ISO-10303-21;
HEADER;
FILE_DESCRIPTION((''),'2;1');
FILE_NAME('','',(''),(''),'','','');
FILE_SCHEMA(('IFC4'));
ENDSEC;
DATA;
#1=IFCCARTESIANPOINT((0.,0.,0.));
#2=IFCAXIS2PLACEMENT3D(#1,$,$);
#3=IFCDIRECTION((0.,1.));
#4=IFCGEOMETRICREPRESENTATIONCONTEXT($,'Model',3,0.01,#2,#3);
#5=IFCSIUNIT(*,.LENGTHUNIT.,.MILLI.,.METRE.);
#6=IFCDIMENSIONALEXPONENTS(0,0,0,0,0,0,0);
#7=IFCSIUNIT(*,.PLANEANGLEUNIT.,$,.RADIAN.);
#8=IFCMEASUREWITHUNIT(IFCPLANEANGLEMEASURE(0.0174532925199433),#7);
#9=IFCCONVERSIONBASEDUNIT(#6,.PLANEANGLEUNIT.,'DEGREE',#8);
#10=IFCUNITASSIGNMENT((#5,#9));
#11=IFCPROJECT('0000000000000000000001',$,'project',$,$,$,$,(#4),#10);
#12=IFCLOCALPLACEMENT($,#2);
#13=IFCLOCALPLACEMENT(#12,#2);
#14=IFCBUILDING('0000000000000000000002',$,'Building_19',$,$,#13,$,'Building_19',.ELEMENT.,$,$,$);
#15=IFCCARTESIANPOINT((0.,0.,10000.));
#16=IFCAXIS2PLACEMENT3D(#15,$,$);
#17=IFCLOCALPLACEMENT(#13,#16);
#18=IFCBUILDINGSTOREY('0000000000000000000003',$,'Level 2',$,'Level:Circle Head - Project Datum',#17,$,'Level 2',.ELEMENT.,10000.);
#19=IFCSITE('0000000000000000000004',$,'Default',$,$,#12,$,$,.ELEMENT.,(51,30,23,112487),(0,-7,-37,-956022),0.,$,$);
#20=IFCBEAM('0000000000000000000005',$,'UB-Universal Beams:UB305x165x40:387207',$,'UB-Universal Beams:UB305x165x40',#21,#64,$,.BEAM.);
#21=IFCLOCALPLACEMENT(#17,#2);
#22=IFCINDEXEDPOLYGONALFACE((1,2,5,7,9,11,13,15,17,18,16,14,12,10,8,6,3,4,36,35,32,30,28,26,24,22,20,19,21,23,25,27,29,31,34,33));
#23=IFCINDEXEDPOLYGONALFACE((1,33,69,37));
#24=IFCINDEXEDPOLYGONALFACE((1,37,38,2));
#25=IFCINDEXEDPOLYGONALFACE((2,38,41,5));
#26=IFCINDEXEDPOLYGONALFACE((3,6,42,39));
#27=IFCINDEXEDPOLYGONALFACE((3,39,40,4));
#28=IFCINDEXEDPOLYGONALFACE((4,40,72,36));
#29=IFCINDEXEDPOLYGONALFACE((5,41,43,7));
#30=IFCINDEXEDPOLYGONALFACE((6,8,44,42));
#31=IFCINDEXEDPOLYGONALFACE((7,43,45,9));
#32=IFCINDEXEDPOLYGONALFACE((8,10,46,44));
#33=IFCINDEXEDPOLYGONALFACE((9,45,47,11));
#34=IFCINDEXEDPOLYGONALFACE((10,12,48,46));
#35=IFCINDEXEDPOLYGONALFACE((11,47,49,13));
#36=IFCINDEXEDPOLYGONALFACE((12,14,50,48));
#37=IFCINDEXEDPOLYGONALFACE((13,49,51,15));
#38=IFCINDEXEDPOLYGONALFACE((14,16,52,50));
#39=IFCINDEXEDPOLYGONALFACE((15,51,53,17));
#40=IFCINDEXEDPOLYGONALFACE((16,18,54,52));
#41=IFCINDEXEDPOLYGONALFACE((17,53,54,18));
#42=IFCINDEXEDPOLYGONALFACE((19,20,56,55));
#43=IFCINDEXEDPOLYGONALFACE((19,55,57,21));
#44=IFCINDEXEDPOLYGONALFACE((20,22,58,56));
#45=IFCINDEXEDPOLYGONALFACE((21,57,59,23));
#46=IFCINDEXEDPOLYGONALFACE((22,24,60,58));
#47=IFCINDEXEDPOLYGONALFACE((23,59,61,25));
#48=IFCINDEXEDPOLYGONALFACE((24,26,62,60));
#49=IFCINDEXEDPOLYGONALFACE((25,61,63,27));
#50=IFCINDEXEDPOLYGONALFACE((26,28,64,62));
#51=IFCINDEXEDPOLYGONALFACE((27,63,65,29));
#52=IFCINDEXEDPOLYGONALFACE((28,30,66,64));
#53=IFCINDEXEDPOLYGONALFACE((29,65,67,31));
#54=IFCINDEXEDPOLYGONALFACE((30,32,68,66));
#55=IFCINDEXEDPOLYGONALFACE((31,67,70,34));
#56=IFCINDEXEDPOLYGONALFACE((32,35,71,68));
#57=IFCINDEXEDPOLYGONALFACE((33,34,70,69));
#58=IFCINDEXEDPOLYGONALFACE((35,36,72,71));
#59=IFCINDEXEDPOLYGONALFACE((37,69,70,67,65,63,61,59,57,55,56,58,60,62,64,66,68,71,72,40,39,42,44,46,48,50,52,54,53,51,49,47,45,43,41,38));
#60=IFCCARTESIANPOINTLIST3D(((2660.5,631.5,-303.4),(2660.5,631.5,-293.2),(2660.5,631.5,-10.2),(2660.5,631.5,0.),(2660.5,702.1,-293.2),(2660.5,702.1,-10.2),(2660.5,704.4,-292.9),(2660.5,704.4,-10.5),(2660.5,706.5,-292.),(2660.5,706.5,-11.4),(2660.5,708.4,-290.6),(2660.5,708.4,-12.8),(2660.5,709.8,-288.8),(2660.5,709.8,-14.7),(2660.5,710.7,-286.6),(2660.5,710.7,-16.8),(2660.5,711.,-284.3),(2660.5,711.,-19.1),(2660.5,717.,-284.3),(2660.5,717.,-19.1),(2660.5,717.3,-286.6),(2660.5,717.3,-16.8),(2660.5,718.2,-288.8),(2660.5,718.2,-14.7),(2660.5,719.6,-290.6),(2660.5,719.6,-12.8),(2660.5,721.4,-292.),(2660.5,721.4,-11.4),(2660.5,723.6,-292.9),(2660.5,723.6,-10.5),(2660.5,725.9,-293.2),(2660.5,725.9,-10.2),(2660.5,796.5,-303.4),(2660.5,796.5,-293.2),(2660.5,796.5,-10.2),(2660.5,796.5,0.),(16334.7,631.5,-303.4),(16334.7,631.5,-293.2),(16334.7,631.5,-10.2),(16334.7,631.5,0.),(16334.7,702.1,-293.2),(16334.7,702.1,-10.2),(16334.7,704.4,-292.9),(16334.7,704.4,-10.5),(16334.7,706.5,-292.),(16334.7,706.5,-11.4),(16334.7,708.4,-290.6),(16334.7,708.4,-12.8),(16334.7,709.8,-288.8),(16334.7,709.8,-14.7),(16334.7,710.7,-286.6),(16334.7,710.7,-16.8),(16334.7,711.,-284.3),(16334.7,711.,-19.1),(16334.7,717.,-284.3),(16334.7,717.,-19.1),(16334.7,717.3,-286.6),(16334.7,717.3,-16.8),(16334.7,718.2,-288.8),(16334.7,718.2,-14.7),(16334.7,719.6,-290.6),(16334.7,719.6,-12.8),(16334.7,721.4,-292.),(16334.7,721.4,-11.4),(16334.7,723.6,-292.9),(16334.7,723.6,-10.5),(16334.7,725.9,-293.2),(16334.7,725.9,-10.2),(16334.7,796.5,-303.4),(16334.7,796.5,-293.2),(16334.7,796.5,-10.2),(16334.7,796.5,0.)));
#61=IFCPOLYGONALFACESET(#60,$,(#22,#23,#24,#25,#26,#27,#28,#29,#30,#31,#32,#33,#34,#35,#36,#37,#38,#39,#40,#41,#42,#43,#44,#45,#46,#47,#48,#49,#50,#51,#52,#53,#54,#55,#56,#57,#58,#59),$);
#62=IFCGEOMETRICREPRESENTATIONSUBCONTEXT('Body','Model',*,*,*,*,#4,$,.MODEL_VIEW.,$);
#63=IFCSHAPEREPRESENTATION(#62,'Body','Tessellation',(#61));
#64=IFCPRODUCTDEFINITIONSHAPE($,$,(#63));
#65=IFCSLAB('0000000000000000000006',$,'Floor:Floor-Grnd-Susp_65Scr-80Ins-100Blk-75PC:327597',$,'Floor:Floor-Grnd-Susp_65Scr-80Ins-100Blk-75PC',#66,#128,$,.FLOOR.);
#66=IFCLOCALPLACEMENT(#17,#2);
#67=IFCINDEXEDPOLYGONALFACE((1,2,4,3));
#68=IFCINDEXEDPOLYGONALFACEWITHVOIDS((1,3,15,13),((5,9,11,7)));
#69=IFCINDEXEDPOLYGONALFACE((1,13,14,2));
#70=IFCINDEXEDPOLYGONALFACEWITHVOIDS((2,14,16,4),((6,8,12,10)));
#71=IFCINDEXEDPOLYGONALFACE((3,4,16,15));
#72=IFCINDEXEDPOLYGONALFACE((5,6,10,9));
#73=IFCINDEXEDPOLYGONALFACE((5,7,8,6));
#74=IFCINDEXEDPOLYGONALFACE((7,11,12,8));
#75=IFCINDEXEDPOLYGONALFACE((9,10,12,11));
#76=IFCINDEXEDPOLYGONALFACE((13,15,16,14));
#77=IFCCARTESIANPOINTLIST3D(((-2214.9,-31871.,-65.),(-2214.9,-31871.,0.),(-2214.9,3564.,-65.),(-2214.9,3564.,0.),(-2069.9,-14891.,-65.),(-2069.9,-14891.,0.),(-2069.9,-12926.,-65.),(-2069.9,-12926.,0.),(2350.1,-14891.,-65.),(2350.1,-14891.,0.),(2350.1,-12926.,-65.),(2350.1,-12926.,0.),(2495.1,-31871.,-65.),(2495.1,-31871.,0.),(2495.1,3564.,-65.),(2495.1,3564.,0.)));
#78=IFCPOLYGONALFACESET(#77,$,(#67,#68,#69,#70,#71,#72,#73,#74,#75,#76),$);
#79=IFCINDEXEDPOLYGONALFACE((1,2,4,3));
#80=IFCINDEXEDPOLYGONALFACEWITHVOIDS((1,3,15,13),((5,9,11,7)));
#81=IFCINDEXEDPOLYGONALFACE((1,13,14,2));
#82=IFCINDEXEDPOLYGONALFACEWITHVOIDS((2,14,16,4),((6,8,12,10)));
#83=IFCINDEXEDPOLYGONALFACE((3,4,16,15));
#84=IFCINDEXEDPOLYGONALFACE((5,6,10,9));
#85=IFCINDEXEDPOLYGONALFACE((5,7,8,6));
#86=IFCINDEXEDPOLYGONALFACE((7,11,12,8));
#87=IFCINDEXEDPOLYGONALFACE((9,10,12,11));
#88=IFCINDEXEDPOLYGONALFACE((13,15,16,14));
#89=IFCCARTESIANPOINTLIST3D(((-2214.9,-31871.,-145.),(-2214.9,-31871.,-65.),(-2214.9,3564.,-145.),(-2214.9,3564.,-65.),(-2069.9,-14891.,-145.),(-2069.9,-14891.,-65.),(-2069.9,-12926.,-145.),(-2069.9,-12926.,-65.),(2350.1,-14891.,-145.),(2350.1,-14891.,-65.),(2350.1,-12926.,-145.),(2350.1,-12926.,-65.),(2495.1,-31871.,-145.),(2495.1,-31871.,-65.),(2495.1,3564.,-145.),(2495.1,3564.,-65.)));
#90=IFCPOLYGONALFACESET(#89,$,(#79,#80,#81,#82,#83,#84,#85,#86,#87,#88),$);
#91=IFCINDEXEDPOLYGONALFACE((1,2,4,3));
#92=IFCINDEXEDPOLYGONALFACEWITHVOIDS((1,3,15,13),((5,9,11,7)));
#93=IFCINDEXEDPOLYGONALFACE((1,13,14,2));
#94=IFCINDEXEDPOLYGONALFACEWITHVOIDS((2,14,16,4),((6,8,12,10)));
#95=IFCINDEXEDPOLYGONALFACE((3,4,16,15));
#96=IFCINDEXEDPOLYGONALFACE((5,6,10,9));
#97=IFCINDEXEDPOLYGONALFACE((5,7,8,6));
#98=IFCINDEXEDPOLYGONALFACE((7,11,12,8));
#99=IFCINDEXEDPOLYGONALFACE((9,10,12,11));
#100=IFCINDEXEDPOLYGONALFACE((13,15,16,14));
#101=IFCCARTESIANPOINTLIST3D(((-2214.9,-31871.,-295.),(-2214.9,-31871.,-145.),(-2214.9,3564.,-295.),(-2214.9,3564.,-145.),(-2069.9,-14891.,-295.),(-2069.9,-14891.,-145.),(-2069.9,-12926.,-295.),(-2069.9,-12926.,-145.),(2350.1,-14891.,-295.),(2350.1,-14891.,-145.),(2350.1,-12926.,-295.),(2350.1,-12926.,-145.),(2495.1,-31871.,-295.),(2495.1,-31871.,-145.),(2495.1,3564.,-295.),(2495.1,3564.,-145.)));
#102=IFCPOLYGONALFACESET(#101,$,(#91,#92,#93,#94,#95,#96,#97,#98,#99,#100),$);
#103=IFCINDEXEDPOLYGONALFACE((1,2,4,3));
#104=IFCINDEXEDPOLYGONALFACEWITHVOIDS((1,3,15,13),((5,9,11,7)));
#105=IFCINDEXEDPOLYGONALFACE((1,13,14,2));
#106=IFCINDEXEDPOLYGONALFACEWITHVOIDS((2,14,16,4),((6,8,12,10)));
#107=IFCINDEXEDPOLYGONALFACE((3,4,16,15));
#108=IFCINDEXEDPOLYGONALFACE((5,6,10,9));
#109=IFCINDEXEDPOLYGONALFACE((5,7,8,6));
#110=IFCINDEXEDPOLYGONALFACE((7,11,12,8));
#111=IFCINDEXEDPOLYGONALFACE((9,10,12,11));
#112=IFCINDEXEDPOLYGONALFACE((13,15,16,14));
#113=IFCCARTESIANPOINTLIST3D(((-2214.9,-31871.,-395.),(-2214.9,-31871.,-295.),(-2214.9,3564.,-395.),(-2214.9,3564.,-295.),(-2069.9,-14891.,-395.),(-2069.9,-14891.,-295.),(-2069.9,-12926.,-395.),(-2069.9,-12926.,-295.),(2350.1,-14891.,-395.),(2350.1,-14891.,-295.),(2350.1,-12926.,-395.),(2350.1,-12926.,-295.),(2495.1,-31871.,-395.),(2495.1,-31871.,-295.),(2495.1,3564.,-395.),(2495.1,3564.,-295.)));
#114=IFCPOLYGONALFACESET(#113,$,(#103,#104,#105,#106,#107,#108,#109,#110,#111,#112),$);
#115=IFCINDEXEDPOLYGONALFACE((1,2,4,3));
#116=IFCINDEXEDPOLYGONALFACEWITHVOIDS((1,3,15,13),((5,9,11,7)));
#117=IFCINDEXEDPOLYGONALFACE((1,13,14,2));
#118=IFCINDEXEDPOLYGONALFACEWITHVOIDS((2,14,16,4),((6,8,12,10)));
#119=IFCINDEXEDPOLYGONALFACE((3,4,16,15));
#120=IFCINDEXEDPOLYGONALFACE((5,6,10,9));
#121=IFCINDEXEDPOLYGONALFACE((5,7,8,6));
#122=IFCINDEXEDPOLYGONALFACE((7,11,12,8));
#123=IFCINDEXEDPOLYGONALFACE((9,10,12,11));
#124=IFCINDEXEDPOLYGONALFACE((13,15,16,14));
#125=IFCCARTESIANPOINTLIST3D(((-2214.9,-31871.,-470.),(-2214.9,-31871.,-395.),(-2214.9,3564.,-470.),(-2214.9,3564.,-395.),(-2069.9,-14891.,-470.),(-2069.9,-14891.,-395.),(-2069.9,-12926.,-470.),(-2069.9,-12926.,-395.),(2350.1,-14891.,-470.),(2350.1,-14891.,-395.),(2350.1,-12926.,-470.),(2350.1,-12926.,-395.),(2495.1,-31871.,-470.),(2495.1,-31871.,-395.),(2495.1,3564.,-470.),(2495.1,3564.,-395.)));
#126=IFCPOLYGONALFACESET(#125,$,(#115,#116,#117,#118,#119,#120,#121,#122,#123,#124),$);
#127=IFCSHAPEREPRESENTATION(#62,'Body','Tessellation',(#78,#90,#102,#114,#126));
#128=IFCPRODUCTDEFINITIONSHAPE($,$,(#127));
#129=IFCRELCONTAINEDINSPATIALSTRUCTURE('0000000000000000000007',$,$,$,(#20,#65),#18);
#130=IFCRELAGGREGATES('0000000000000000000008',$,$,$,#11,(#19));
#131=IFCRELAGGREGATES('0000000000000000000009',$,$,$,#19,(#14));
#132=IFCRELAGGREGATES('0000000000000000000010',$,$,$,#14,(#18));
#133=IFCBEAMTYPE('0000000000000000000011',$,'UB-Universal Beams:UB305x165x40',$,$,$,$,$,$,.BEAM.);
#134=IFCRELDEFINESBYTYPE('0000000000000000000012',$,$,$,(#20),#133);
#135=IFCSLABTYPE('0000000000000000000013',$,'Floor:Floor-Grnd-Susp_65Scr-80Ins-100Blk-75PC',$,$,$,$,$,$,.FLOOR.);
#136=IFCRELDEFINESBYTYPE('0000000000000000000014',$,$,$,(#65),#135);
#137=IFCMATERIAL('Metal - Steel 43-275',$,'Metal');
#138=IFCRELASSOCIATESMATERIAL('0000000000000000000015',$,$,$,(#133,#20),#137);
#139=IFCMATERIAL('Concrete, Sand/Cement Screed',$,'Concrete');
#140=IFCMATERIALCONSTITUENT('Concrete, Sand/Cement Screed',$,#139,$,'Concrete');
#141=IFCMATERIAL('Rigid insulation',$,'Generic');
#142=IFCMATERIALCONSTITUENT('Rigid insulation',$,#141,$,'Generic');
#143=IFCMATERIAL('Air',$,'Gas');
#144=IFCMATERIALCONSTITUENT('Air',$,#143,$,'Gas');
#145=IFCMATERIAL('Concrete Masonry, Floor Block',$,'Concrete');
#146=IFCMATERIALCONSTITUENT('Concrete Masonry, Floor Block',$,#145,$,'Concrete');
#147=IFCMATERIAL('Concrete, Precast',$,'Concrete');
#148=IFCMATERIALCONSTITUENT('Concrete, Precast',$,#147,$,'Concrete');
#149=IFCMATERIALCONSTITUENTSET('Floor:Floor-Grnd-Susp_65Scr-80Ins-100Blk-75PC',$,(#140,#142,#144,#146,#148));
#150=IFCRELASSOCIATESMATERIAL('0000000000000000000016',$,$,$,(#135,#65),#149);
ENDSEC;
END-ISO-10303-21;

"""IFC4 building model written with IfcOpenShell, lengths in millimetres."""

from ifc_helpers import new_model, entity, si_unit, converted_unit, direction, frame, origin, place, context, subcontext, project, spatial, line, arc, indexed_curve, outline, extrude, source, transform, mapped, material, constituent, constituent_set, type_object, type_shapes, element, save


model = new_model("IFC4")

# Units and contexts
model_context = context("Model", 3, precision=0.01, world=origin(), true_north=direction((0.0, 1.0)))
body_context = subcontext(model_context, "Body", "Model", "MODEL_VIEW")
ifc_project = project(units=[si_unit("LENGTHUNIT", "METRE", prefix="MILLI"), converted_unit("PLANEANGLEUNIT", "DEGREE", entity("IfcPlaneAngleMeasure", 0.0174532925199433), si_unit("PLANEANGLEUNIT", "RADIAN"), dimensions=[0, 0, 0, 0, 0, 0, 0])], contexts=[model_context])

# Site, building, storey
site_placement = place(None, origin())
site = spatial("IfcSite", under=ifc_project, at=site_placement, Name="Default", CompositionType="ELEMENT", RefLatitude=(51, 30, 23, 112487), RefLongitude=(0, -7, -37, -956022), RefElevation=0.0)
building_placement = place(site_placement, origin())
building = spatial("IfcBuilding", under=site, at=building_placement, Name="Building_19", LongName="Building_19", CompositionType="ELEMENT")
storey_placement = place(building_placement, frame((0.0, 0.0, 10000.0)))
storey = spatial("IfcBuildingStorey", under=building, at=storey_placement, Name="Level 2", ObjectType="Level:Circle Head - Project Datum", LongName="Level 2", CompositionType="ELEMENT", Elevation=10000.0)

# Beam
ifc_material_1 = material(Name="Metal - Steel 43-275", Category="Metal")
beam_type_1 = type_object("IfcBeamType", Name="UB-Universal Beams:UB305x165x40", PredefinedType="BEAM", material=ifc_material_1)
shared_shape_1 = source(origin(), body_context, "Body", "SweptSolid", [
    extrude(outline(indexed_curve([(-82.5, -141.5), (-82.5, -151.7), (82.5, -151.7), (82.5, -141.5), (11.9, -141.5), (5.6, -138.9), (3.0, -132.6), (3.0, 132.6), (5.6, 138.9), (11.9, 141.5), (82.5, 141.5), (82.5, 151.7), (-82.5, 151.7), (-82.5, 141.5), (-11.9, 141.5), (-5.6, 138.9), (-3.0, 132.6), (-3.0, -132.6), (-5.6, -138.9), (-11.9, -141.5)], segments=[line(1, 2, 3, 4, 5), arc(5, 6, 7), line(7, 8), arc(8, 9, 10), line(10, 11, 12, 13, 14, 15), arc(15, 16, 17), line(17, 18), arc(18, 19, 20), line(20, 1)], self_intersect=False)), frame((-6837.1, 0.0, 0.0), z_axis=(-1.0, 0.0, 0.0), x_axis=(0.0, -1.0, 0.0)), (0.0, 0.0, -1.0), 13674.2),
])
type_shapes(beam_type_1, [shared_shape_1])
beam_1_placement = place(storey_placement, frame((9497.6, 714.0, -151.7), z_axis=(0.0, 0.0, 1.0), x_axis=(-1.0, 0.0, 0.0)))
element("IfcBeam", 1, at=beam_1_placement, inside=storey, type_object=beam_type_1, material=ifc_material_1, Name="UB-Universal Beams:UB305x165x40:387207", ObjectType="UB-Universal Beams:UB305x165x40", PredefinedType="BEAM", context=body_context, shape_type="MappedRepresentation", body=[
    mapped(shared_shape_1, transform((0.0, 0.0, 0.0), scale=1.0)),
])

# Slab, opening
ifc_material_2 = material(Name="Concrete, Sand/Cement Screed", Category="Concrete")
ifc_constituent_1 = constituent(ifc_material_2, Name="Concrete, Sand/Cement Screed", Category="Concrete")
ifc_material_3 = material(Name="Rigid insulation", Category="Generic")
ifc_constituent_2 = constituent(ifc_material_3, Name="Rigid insulation", Category="Generic")
ifc_material_4 = material(Name="Air", Category="Gas")
ifc_constituent_3 = constituent(ifc_material_4, Name="Air", Category="Gas")
ifc_material_5 = material(Name="Concrete Masonry, Floor Block", Category="Concrete")
ifc_constituent_4 = constituent(ifc_material_5, Name="Concrete Masonry, Floor Block", Category="Concrete")
ifc_material_6 = material(Name="Concrete, Precast", Category="Concrete")
ifc_constituent_5 = constituent(ifc_material_6, Name="Concrete, Precast", Category="Concrete")
ifc_constituent_set_1 = constituent_set(constituents=[ifc_constituent_1, ifc_constituent_2, ifc_constituent_3, ifc_constituent_4, ifc_constituent_5], Name="Floor:Floor-Grnd-Susp_65Scr-80Ins-100Blk-75PC")
slab_type = type_object("IfcSlabType", Name="Floor:Floor-Grnd-Susp_65Scr-80Ins-100Blk-75PC", PredefinedType="FLOOR", material=ifc_constituent_set_1)
slab_1_placement = place(storey_placement, origin())
slab_1 = element("IfcSlab", 2, at=slab_1_placement, inside=storey, type_object=slab_type, material=ifc_constituent_set_1, Name="Floor:Floor-Grnd-Susp_65Scr-80Ins-100Blk-75PC:327597", ObjectType="Floor:Floor-Grnd-Susp_65Scr-80Ins-100Blk-75PC", PredefinedType="FLOOR", context=body_context, shape_type="SweptSolid", body=[
    extrude(outline(indexed_curve([(-2355.0, -17717.5), (2355.0, -17717.5), (2355.0, 17717.5), (-2355.0, 17717.5), (-2355.0, -17717.5)], self_intersect=False), holes=[indexed_curve([(-2210.0, 737.5), (2210.0, 737.5), (2210.0, -1227.5), (-2210.0, -1227.5), (-2210.0, 737.5)], self_intersect=False)]), frame((140.1, -14153.5, -65.0), z_axis=(0.0, 0.0, 1.0), x_axis=(-1.0, 0.0, 0.0)), (0.0, 0.0, 1.0), 65.0),
    extrude(outline(indexed_curve([(-2355.0, -17717.5), (2355.0, -17717.5), (2355.0, 17717.5), (-2355.0, 17717.5), (-2355.0, -17717.5)], self_intersect=False), holes=[indexed_curve([(-2210.0, 737.5), (2210.0, 737.5), (2210.0, -1227.5), (-2210.0, -1227.5), (-2210.0, 737.5)], self_intersect=False)]), frame((140.1, -14153.5, -145.0), z_axis=(0.0, 0.0, 1.0), x_axis=(-1.0, 0.0, 0.0)), (0.0, 0.0, 1.0), 80.0),
    extrude(outline(indexed_curve([(-2355.0, -17717.5), (2355.0, -17717.5), (2355.0, 17717.5), (-2355.0, 17717.5), (-2355.0, -17717.5)], self_intersect=False), holes=[indexed_curve([(-2210.0, 737.5), (2210.0, 737.5), (2210.0, -1227.5), (-2210.0, -1227.5), (-2210.0, 737.5)], self_intersect=False)]), frame((140.1, -14153.5, -295.0), z_axis=(0.0, 0.0, 1.0), x_axis=(-1.0, 0.0, 0.0)), (0.0, 0.0, 1.0), 150.0),
    extrude(outline(indexed_curve([(-2355.0, -17717.5), (2355.0, -17717.5), (2355.0, 17717.5), (-2355.0, 17717.5), (-2355.0, -17717.5)], self_intersect=False), holes=[indexed_curve([(-2210.0, 737.5), (2210.0, 737.5), (2210.0, -1227.5), (-2210.0, -1227.5), (-2210.0, 737.5)], self_intersect=False)]), frame((140.1, -14153.5, -395.0), z_axis=(0.0, 0.0, 1.0), x_axis=(-1.0, 0.0, 0.0)), (0.0, 0.0, 1.0), 100.0),
    extrude(outline(indexed_curve([(-2355.0, -17717.5), (2355.0, -17717.5), (2355.0, 17717.5), (-2355.0, 17717.5), (-2355.0, -17717.5)], self_intersect=False), holes=[indexed_curve([(-2210.0, 737.5), (2210.0, 737.5), (2210.0, -1227.5), (-2210.0, -1227.5), (-2210.0, 737.5)], self_intersect=False)]), frame((140.1, -14153.5, -470.0), z_axis=(0.0, 0.0, 1.0), x_axis=(-1.0, 0.0, 0.0)), (0.0, 0.0, 1.0), 75.0),
])
opening_1_placement = place(slab_1_placement, origin())
element("IfcOpeningElement", 3, at=opening_1_placement, cuts=slab_1, PredefinedType="OPENING", context=body_context, shape_type="SweptSolid", body=[
    extrude(outline(indexed_curve([(-982.5, -2210.0), (982.5, -2210.0), (982.5, 2210.0), (-982.5, 2210.0), (-982.5, -2210.0)], self_intersect=False)), frame((140.1, -13908.5, -470.0), z_axis=(0.0, 0.0, 1.0), x_axis=(0.0, 1.0, 0.0)), (0.0, 0.0, 1.0), 470.0),
])

save(model, "model.ifc")
